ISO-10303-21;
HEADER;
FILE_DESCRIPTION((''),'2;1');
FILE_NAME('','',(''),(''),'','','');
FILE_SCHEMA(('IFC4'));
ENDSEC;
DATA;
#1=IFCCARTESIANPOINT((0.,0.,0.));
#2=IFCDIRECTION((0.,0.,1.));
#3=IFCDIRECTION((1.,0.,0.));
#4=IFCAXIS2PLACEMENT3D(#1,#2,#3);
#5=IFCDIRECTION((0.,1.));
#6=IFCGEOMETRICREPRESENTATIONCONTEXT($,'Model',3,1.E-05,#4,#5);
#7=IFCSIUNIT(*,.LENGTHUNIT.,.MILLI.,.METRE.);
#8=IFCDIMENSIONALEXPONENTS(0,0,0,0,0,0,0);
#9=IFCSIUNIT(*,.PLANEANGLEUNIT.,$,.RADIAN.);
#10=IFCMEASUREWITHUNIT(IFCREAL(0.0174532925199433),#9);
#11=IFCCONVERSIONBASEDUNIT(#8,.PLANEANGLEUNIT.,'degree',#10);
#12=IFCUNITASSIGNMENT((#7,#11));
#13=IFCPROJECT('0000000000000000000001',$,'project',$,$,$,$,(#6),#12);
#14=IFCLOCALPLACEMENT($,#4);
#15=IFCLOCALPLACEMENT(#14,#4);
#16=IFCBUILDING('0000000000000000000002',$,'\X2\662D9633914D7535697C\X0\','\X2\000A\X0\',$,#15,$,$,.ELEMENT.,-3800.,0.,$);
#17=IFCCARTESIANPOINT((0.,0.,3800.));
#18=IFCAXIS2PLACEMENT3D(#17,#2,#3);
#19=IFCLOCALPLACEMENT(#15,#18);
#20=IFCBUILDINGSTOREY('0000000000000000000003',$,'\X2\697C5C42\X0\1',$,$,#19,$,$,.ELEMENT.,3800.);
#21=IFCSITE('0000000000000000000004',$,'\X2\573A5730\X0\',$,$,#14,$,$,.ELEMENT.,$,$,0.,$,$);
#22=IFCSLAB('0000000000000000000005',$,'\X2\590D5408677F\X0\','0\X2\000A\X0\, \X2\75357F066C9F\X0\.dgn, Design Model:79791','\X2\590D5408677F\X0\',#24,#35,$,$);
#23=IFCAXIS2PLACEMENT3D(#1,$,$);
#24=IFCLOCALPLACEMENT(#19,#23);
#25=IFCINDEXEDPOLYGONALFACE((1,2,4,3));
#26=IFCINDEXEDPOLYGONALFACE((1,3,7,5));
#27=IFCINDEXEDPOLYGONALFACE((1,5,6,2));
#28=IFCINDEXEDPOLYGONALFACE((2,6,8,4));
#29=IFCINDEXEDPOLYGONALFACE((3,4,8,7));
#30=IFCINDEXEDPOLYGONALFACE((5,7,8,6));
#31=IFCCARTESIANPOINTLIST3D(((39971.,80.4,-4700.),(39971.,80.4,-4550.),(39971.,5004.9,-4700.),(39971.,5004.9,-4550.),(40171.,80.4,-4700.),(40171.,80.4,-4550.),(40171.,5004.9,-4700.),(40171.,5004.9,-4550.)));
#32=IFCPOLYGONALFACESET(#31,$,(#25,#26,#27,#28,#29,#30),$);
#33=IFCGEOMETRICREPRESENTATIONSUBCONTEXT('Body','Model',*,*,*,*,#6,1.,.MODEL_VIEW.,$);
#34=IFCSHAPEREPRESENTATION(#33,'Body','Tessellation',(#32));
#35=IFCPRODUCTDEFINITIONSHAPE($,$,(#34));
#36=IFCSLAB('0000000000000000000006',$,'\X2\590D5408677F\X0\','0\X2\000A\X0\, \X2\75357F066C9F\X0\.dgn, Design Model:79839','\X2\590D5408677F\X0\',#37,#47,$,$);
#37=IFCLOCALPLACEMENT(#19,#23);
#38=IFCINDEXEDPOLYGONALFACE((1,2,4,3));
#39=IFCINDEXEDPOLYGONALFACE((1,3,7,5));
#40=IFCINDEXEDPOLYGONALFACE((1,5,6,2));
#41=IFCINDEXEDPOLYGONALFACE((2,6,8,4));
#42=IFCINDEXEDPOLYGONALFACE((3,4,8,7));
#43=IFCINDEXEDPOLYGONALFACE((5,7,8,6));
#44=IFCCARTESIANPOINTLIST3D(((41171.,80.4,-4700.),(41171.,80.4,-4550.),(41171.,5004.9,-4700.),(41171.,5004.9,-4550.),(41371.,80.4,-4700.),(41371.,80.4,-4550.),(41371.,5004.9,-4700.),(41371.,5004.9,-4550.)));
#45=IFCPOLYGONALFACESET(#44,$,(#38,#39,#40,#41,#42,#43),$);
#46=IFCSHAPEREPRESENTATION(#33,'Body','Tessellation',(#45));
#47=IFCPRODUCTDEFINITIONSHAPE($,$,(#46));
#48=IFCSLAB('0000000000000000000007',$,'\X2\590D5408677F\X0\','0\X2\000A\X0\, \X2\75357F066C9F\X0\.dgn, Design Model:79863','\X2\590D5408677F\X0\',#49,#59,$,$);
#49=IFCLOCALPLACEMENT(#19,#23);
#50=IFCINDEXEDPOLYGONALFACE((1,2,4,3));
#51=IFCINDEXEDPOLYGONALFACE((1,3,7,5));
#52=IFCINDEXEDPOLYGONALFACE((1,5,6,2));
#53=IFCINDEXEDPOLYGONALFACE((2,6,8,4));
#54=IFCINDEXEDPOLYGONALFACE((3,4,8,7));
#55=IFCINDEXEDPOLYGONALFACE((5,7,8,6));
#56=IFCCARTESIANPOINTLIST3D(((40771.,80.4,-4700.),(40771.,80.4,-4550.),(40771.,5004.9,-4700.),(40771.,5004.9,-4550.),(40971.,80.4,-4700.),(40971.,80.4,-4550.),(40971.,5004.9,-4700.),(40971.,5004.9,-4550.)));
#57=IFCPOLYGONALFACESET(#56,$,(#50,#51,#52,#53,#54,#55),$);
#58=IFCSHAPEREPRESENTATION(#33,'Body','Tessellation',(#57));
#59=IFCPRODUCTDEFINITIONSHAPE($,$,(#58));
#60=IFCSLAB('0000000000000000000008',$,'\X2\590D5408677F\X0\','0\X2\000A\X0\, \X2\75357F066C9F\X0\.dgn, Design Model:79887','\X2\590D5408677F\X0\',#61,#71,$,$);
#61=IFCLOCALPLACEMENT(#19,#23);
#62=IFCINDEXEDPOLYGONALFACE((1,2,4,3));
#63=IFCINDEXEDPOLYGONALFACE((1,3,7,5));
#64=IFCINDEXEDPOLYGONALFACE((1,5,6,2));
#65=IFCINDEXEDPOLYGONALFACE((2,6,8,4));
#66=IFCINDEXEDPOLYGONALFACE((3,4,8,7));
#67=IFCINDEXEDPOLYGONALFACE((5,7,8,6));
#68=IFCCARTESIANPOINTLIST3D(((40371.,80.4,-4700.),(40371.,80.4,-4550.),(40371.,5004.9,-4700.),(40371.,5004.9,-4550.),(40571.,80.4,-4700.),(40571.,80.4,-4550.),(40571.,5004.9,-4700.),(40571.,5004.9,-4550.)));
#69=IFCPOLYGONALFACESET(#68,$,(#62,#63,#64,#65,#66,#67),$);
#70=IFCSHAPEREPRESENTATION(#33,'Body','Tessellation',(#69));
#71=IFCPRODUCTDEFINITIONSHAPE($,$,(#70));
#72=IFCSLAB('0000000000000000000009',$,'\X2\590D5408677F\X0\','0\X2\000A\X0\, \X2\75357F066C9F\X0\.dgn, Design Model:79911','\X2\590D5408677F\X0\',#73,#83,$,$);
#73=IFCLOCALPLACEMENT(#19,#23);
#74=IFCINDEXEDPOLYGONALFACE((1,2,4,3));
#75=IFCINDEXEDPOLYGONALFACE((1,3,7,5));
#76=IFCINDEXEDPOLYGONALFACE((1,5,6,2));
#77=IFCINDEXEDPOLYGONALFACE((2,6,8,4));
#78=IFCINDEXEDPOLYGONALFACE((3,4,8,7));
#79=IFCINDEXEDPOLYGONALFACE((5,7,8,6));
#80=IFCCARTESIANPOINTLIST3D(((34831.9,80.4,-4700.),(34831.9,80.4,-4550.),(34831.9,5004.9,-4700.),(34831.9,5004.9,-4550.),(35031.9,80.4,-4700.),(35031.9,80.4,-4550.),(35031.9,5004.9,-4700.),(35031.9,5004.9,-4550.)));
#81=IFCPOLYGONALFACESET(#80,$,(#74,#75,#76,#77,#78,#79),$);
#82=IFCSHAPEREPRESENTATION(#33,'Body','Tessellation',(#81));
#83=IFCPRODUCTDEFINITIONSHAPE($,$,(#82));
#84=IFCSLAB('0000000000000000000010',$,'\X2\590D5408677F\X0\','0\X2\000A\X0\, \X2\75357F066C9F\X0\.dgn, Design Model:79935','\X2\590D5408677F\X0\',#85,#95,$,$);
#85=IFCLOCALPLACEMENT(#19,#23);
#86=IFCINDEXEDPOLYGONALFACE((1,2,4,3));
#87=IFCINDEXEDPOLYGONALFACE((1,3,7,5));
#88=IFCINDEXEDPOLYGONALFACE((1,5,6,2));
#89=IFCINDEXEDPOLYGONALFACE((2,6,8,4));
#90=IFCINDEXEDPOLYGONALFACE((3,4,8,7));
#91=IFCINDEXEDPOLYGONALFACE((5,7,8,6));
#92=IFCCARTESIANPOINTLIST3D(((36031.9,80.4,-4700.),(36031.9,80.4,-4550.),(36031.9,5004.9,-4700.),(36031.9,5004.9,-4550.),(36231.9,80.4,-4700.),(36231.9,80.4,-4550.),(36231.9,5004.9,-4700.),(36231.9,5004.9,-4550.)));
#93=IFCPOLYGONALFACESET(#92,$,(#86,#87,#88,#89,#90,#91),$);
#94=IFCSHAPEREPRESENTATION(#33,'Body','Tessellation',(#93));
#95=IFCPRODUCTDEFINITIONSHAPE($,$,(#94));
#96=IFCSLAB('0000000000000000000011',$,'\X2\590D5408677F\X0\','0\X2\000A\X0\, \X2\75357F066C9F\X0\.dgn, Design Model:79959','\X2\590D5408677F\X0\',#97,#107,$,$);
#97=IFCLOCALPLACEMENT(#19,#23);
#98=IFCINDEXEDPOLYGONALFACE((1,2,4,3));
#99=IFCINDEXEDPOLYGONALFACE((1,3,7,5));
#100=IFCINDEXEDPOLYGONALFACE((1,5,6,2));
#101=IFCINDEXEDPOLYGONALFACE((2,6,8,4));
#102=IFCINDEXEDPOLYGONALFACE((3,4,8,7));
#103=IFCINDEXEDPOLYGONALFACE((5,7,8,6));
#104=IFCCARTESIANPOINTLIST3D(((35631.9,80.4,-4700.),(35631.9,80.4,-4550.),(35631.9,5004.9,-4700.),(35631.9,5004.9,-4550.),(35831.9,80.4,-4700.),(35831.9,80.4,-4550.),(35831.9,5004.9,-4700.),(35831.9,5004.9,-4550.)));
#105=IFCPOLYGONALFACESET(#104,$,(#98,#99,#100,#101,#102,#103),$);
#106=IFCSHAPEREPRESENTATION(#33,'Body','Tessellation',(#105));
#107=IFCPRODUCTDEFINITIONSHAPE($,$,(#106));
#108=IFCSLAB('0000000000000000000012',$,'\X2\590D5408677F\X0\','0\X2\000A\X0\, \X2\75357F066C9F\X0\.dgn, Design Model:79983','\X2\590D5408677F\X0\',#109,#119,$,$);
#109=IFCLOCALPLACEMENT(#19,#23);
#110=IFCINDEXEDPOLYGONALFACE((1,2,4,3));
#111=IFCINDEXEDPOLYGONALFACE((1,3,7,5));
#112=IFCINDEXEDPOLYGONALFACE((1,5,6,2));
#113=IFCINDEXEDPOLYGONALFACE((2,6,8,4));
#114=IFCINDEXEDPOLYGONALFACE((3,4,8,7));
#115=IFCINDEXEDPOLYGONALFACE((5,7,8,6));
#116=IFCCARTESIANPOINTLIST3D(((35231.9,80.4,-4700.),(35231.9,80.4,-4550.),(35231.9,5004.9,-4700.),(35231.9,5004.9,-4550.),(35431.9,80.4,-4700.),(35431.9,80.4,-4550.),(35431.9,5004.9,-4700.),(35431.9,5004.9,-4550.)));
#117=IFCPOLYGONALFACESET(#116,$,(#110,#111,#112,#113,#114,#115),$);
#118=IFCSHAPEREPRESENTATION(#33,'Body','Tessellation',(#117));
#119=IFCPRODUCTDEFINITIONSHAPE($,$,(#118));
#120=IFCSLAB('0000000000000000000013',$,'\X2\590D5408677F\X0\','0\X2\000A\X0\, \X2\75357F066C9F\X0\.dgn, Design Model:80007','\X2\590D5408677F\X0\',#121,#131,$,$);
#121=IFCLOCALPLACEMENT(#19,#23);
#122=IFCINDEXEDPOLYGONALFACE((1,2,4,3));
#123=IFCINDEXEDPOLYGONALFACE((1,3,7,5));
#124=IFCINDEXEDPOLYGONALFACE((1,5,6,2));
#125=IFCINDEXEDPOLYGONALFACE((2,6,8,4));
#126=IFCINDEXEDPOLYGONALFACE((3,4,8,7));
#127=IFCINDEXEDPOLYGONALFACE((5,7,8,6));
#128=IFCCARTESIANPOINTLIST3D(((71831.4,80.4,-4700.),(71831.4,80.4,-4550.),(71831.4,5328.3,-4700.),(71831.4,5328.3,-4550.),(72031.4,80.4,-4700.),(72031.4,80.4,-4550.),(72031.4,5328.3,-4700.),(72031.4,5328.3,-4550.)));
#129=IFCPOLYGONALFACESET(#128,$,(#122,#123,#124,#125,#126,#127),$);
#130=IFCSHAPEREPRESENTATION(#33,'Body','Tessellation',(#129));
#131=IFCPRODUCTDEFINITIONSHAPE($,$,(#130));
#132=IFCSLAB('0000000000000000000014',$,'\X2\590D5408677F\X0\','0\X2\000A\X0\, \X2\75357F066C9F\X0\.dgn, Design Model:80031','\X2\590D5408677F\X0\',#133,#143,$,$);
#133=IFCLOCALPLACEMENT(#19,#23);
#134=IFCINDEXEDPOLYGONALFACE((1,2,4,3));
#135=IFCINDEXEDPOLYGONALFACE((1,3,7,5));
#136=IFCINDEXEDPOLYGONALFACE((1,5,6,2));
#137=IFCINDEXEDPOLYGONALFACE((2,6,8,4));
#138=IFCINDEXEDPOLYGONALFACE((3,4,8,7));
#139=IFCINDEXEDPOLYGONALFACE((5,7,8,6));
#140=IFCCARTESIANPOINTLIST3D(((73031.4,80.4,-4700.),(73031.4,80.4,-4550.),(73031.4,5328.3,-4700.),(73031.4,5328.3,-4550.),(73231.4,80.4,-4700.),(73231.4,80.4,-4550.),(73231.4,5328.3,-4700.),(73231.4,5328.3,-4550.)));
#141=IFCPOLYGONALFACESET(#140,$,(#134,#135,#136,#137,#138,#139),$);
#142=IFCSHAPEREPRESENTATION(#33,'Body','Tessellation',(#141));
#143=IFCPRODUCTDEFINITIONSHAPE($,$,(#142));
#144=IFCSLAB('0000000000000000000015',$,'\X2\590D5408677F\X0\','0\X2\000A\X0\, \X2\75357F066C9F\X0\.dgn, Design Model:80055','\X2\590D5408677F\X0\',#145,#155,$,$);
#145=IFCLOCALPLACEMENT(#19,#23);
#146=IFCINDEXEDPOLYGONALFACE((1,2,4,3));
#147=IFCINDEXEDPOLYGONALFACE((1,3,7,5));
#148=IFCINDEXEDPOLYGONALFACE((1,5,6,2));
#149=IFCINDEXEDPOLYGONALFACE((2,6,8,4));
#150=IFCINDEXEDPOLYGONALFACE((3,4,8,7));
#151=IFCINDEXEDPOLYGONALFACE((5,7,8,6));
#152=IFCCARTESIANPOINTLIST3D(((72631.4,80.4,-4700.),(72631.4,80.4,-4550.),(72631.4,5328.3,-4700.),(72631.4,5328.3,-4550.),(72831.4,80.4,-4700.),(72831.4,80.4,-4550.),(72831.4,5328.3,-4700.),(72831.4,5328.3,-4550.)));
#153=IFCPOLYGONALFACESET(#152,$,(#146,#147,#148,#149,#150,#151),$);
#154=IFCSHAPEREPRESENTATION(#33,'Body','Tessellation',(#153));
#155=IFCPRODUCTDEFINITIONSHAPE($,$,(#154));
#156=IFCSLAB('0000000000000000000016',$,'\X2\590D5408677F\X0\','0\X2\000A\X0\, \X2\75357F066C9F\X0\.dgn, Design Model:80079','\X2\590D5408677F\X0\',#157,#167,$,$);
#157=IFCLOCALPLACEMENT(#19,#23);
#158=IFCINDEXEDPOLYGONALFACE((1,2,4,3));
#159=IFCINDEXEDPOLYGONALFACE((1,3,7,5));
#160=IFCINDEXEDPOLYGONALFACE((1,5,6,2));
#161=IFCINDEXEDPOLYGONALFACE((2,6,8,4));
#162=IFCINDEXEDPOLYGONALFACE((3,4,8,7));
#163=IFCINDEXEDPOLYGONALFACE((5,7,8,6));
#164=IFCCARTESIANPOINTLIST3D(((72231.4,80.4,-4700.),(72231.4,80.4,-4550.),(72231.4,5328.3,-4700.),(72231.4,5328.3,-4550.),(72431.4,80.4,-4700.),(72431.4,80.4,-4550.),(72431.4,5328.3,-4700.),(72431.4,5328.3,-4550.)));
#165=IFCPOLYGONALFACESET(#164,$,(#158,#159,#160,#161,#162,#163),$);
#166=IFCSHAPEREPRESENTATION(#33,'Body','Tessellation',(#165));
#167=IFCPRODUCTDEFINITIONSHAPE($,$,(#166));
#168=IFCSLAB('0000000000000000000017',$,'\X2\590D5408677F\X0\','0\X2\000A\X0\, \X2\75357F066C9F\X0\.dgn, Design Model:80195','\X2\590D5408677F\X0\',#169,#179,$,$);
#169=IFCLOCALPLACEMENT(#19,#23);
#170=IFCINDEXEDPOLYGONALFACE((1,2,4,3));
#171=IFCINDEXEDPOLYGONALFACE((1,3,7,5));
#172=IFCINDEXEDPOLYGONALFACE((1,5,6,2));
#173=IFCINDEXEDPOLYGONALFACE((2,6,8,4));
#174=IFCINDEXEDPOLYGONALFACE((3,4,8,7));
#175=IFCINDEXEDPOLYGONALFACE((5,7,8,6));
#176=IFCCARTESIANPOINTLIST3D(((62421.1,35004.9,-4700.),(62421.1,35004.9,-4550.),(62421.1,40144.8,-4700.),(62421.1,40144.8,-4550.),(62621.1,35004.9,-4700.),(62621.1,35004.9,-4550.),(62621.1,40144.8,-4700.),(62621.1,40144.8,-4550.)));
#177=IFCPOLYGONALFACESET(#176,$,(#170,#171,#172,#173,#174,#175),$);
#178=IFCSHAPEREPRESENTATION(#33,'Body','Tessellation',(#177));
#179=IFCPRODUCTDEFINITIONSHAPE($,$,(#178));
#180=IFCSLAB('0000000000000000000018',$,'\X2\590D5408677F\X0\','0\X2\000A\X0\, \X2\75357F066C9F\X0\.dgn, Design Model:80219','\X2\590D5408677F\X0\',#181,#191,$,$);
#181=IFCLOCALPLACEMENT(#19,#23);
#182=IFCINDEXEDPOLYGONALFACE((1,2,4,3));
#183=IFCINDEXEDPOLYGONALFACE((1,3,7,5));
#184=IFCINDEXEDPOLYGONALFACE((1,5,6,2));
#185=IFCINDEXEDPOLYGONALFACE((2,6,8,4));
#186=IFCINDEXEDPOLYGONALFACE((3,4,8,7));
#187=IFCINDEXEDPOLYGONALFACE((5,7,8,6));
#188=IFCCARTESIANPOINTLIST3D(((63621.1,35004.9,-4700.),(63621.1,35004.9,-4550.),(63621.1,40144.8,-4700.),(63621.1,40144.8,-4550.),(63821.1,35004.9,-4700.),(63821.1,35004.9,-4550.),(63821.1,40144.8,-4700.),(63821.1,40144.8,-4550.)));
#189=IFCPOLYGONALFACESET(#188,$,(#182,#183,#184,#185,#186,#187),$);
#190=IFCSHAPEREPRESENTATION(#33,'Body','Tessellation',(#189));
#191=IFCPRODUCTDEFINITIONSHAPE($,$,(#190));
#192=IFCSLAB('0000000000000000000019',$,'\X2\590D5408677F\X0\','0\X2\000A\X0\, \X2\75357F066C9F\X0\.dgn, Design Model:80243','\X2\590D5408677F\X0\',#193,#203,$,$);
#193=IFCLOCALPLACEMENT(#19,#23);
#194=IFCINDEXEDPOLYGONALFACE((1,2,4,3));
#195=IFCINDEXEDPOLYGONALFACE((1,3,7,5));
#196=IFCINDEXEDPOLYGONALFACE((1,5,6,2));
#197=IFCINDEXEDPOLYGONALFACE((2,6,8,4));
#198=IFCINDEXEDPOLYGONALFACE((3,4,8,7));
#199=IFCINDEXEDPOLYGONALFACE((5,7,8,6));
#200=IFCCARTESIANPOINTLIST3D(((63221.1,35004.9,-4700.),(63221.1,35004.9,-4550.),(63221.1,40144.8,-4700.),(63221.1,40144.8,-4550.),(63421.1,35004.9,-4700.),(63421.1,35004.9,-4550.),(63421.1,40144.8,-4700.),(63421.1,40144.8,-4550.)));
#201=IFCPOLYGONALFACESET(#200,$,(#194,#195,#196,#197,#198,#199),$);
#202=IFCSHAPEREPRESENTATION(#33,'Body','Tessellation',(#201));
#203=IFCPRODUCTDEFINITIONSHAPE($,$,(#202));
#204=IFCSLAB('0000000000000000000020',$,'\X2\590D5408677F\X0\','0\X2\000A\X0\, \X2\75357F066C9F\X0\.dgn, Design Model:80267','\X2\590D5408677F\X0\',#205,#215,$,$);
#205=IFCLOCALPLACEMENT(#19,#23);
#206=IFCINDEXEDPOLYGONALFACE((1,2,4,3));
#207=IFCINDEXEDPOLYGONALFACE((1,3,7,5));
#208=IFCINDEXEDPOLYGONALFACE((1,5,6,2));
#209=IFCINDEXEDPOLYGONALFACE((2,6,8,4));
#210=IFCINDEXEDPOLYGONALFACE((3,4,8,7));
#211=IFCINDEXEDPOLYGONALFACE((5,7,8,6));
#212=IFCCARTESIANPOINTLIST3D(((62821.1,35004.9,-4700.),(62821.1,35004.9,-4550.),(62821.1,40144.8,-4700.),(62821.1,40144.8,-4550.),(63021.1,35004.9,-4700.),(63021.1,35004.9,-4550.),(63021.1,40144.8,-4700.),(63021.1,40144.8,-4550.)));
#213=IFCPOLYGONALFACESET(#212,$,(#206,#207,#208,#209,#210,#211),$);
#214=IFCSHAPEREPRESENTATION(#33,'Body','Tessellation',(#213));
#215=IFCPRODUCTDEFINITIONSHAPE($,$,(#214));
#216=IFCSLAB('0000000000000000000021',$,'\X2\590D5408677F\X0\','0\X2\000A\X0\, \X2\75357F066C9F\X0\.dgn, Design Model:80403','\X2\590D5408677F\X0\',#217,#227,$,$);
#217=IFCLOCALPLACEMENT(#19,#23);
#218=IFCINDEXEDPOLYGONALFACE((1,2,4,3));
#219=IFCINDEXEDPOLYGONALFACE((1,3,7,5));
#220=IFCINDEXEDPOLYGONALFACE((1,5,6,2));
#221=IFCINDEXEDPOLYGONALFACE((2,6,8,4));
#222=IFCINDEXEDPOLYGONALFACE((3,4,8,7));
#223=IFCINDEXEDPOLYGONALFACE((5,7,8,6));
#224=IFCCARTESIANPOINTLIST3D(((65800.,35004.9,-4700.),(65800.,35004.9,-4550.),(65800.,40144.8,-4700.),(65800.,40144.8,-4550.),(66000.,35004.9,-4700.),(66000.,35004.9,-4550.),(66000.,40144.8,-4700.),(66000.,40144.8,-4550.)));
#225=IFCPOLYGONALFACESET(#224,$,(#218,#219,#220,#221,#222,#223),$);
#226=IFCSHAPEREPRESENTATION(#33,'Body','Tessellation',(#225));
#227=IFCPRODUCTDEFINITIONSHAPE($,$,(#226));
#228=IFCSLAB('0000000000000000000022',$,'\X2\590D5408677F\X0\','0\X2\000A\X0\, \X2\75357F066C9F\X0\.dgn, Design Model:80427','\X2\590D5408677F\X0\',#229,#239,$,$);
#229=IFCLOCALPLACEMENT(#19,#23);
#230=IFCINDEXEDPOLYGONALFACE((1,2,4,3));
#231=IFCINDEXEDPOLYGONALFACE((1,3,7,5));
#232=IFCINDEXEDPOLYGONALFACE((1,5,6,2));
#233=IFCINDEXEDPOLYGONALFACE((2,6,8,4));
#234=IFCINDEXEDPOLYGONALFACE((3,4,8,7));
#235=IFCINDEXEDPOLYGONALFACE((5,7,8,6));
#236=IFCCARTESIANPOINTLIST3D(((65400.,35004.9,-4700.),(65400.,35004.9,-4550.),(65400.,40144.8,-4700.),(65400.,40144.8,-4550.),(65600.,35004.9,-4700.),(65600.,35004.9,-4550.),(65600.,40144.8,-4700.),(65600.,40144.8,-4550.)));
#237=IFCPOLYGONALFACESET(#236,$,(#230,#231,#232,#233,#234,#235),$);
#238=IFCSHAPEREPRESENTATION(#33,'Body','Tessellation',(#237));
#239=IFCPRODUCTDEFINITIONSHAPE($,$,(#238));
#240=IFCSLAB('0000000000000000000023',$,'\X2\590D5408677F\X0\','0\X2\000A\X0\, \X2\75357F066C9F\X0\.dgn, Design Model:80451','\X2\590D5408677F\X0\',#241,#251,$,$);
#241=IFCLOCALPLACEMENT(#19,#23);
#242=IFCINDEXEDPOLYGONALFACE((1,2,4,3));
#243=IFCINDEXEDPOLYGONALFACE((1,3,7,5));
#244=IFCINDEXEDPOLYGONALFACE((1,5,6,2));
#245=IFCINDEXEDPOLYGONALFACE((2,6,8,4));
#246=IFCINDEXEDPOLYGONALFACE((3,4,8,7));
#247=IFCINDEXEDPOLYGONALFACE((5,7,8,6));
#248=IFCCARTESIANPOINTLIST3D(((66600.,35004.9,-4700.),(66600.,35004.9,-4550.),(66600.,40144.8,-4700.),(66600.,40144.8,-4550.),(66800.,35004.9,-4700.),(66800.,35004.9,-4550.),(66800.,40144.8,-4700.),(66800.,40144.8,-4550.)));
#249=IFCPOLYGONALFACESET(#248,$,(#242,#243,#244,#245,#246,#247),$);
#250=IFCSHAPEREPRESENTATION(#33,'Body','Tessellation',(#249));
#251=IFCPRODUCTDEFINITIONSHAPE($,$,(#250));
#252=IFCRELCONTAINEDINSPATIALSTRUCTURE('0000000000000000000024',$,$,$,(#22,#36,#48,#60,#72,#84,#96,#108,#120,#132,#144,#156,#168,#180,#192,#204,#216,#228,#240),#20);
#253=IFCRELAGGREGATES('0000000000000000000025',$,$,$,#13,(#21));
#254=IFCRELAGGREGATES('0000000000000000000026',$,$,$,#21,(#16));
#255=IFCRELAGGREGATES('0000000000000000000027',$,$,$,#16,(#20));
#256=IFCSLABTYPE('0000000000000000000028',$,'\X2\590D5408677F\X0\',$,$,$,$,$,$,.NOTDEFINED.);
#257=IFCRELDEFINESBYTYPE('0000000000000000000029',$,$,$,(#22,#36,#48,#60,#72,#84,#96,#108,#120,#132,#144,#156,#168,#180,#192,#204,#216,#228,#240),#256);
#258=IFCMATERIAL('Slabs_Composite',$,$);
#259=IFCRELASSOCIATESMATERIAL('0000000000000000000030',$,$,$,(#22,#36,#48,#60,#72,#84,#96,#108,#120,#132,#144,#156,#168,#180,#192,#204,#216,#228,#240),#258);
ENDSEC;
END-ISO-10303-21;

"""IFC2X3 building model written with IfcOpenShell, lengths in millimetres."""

from ifc_helpers import new_model, entity, si_unit, converted_unit, direction, frame, frame_2d, origin_with_axes, place, context, subcontext, project, spatial, rectangle, extrude, material, type_object, element, save


model = new_model("IFC2X3")

# Units and contexts
model_context = context("Model", 3, precision=1e-05, world=origin_with_axes(), true_north=direction((0.0, 1.0)))
body_context = subcontext(model_context, "Body", "Model", "MODEL_VIEW", scale=1.0)
ifc_project = project(units=[si_unit("LENGTHUNIT", "METRE", prefix="MILLI"), converted_unit("PLANEANGLEUNIT", "degree", entity("IfcReal", 0.0174532925199433), si_unit("PLANEANGLEUNIT", "RADIAN"), dimensions=[0, 0, 0, 0, 0, 0, 0])], contexts=[model_context])

# Site, building, storey
site_placement = place(None, origin_with_axes())
site = spatial("IfcSite", under=ifc_project, at=site_placement, Name="场地", CompositionType="ELEMENT", RefElevation=0.0)
building_placement = place(site_placement, origin_with_axes())
building = spatial("IfcBuilding", under=site, at=building_placement, Name="昭阳配电楼", Description="\n", CompositionType="ELEMENT", ElevationOfRefHeight=-3800.0, ElevationOfTerrain=0.0)
storey_placement = place(building_placement, frame((0.0, 0.0, 3800.0), z_axis=(0.0, 0.0, 1.0), x_axis=(1.0, 0.0, 0.0)))
storey = spatial("IfcBuildingStorey", under=building, at=storey_placement, Name="楼层1", CompositionType="ELEMENT", Elevation=3800.0)

# Slabs
ifc_material = material(Name="Slabs_Composite")
slab_type = type_object("IfcSlabType", Name="复合板", PredefinedType="NOTDEFINED")
for number, where, z_axis, x_axis, name, description in (
    (1, (39971.0, 5004.9, -4550.0), (0.0, 0.0, -1.0), (1.0, 0.0, 0.0), "复合板", "0\n, 电缆沟.dgn, Design Model:79791"),
    (2, (41171.0, 5004.9, -4550.0), (0.0, 0.0, -1.0), (1.0, 0.0, 0.0), "复合板", "0\n, 电缆沟.dgn, Design Model:79839"),
    (3, (40771.0, 5004.9, -4550.0), (0.0, 0.0, -1.0), (1.0, 0.0, 0.0), "复合板", "0\n, 电缆沟.dgn, Design Model:79863"),
    (4, (40371.0, 5004.9, -4550.0), (0.0, 0.0, -1.0), (1.0, 0.0, 0.0), "复合板", "0\n, 电缆沟.dgn, Design Model:79887"),
    (5, (34831.9, 5004.9, -4550.0), (0.0, 0.0, -1.0), (1.0, 0.0, 0.0), "复合板", "0\n, 电缆沟.dgn, Design Model:79911"),
    (6, (36031.9, 5004.9, -4550.0), (0.0, 0.0, -1.0), (1.0, 0.0, 0.0), "复合板", "0\n, 电缆沟.dgn, Design Model:79935"),
    (7, (35631.9, 5004.9, -4550.0), (0.0, 0.0, -1.0), (1.0, 0.0, 0.0), "复合板", "0\n, 电缆沟.dgn, Design Model:79959"),
    (8, (35231.9, 5004.9, -4550.0), (0.0, 0.0, -1.0), (1.0, 0.0, 0.0), "复合板", "0\n, 电缆沟.dgn, Design Model:79983"),
):
    element("IfcSlab", number, at=place(storey_placement, frame(where, z_axis=z_axis, x_axis=x_axis)), inside=storey, type_object=slab_type, material=ifc_material, Name=name, Description=description, ObjectType="复合板", context=body_context, shape_type="SweptSolid", body=[
        extrude(rectangle(XDim=200.0, YDim=4924.5, at=frame_2d((100.0, 2462.2), x_axis=(1.0, 0.0))), origin_with_axes(), (0.0, 0.0, 1.0), 150.0),
    ])
for number, where, z_axis, x_axis, name, description in (
    (9, (71831.4, 5328.3, -4550.0), (0.0, 0.0, -1.0), (1.0, 0.0, 0.0), "复合板", "0\n, 电缆沟.dgn, Design Model:80007"),
    (10, (73031.4, 5328.3, -4550.0), (0.0, 0.0, -1.0), (1.0, 0.0, 0.0), "复合板", "0\n, 电缆沟.dgn, Design Model:80031"),
    (11, (72631.4, 5328.3, -4550.0), (0.0, 0.0, -1.0), (1.0, 0.0, 0.0), "复合板", "0\n, 电缆沟.dgn, Design Model:80055"),
    (12, (72231.4, 5328.3, -4550.0), (0.0, 0.0, -1.0), (1.0, 0.0, 0.0), "复合板", "0\n, 电缆沟.dgn, Design Model:80079"),
):
    element("IfcSlab", number, at=place(storey_placement, frame(where, z_axis=z_axis, x_axis=x_axis)), inside=storey, type_object=slab_type, material=ifc_material, Name=name, Description=description, ObjectType="复合板", context=body_context, shape_type="SweptSolid", body=[
        extrude(rectangle(XDim=200.0, YDim=5247.9, at=frame_2d((100.0, 2623.9), x_axis=(1.0, 0.0))), origin_with_axes(), (0.0, 0.0, 1.0), 150.0),
    ])
for number, where, z_axis, x_axis, name, description in (
    (13, (62421.1, 40144.8, -4550.0), (0.0, 0.0, -1.0), (1.0, 0.0, 0.0), "复合板", "0\n, 电缆沟.dgn, Design Model:80195"),
    (14, (63621.1, 40144.8, -4550.0), (0.0, 0.0, -1.0), (1.0, 0.0, 0.0), "复合板", "0\n, 电缆沟.dgn, Design Model:80219"),
    (15, (63221.1, 40144.8, -4550.0), (0.0, 0.0, -1.0), (1.0, 0.0, 0.0), "复合板", "0\n, 电缆沟.dgn, Design Model:80243"),
    (16, (62821.1, 40144.8, -4550.0), (0.0, 0.0, -1.0), (1.0, 0.0, 0.0), "复合板", "0\n, 电缆沟.dgn, Design Model:80267"),
    (17, (65800.0, 40144.8, -4550.0), (0.0, 0.0, -1.0), (1.0, 0.0, 0.0), "复合板", "0\n, 电缆沟.dgn, Design Model:80403"),
    (18, (65400.0, 40144.8, -4550.0), (0.0, 0.0, -1.0), (1.0, 0.0, 0.0), "复合板", "0\n, 电缆沟.dgn, Design Model:80427"),
    (19, (66600.0, 40144.8, -4550.0), (0.0, 0.0, -1.0), (1.0, 0.0, 0.0), "复合板", "0\n, 电缆沟.dgn, Design Model:80451"),
):
    element("IfcSlab", number, at=place(storey_placement, frame(where, z_axis=z_axis, x_axis=x_axis)), inside=storey, type_object=slab_type, material=ifc_material, Name=name, Description=description, ObjectType="复合板", context=body_context, shape_type="SweptSolid", body=[
        extrude(rectangle(XDim=200.0, YDim=5139.9, at=frame_2d((100.0, 2570.0), x_axis=(1.0, 0.0))), origin_with_axes(), (0.0, 0.0, 1.0), 150.0),
    ])

save(model, "model.ifc")
